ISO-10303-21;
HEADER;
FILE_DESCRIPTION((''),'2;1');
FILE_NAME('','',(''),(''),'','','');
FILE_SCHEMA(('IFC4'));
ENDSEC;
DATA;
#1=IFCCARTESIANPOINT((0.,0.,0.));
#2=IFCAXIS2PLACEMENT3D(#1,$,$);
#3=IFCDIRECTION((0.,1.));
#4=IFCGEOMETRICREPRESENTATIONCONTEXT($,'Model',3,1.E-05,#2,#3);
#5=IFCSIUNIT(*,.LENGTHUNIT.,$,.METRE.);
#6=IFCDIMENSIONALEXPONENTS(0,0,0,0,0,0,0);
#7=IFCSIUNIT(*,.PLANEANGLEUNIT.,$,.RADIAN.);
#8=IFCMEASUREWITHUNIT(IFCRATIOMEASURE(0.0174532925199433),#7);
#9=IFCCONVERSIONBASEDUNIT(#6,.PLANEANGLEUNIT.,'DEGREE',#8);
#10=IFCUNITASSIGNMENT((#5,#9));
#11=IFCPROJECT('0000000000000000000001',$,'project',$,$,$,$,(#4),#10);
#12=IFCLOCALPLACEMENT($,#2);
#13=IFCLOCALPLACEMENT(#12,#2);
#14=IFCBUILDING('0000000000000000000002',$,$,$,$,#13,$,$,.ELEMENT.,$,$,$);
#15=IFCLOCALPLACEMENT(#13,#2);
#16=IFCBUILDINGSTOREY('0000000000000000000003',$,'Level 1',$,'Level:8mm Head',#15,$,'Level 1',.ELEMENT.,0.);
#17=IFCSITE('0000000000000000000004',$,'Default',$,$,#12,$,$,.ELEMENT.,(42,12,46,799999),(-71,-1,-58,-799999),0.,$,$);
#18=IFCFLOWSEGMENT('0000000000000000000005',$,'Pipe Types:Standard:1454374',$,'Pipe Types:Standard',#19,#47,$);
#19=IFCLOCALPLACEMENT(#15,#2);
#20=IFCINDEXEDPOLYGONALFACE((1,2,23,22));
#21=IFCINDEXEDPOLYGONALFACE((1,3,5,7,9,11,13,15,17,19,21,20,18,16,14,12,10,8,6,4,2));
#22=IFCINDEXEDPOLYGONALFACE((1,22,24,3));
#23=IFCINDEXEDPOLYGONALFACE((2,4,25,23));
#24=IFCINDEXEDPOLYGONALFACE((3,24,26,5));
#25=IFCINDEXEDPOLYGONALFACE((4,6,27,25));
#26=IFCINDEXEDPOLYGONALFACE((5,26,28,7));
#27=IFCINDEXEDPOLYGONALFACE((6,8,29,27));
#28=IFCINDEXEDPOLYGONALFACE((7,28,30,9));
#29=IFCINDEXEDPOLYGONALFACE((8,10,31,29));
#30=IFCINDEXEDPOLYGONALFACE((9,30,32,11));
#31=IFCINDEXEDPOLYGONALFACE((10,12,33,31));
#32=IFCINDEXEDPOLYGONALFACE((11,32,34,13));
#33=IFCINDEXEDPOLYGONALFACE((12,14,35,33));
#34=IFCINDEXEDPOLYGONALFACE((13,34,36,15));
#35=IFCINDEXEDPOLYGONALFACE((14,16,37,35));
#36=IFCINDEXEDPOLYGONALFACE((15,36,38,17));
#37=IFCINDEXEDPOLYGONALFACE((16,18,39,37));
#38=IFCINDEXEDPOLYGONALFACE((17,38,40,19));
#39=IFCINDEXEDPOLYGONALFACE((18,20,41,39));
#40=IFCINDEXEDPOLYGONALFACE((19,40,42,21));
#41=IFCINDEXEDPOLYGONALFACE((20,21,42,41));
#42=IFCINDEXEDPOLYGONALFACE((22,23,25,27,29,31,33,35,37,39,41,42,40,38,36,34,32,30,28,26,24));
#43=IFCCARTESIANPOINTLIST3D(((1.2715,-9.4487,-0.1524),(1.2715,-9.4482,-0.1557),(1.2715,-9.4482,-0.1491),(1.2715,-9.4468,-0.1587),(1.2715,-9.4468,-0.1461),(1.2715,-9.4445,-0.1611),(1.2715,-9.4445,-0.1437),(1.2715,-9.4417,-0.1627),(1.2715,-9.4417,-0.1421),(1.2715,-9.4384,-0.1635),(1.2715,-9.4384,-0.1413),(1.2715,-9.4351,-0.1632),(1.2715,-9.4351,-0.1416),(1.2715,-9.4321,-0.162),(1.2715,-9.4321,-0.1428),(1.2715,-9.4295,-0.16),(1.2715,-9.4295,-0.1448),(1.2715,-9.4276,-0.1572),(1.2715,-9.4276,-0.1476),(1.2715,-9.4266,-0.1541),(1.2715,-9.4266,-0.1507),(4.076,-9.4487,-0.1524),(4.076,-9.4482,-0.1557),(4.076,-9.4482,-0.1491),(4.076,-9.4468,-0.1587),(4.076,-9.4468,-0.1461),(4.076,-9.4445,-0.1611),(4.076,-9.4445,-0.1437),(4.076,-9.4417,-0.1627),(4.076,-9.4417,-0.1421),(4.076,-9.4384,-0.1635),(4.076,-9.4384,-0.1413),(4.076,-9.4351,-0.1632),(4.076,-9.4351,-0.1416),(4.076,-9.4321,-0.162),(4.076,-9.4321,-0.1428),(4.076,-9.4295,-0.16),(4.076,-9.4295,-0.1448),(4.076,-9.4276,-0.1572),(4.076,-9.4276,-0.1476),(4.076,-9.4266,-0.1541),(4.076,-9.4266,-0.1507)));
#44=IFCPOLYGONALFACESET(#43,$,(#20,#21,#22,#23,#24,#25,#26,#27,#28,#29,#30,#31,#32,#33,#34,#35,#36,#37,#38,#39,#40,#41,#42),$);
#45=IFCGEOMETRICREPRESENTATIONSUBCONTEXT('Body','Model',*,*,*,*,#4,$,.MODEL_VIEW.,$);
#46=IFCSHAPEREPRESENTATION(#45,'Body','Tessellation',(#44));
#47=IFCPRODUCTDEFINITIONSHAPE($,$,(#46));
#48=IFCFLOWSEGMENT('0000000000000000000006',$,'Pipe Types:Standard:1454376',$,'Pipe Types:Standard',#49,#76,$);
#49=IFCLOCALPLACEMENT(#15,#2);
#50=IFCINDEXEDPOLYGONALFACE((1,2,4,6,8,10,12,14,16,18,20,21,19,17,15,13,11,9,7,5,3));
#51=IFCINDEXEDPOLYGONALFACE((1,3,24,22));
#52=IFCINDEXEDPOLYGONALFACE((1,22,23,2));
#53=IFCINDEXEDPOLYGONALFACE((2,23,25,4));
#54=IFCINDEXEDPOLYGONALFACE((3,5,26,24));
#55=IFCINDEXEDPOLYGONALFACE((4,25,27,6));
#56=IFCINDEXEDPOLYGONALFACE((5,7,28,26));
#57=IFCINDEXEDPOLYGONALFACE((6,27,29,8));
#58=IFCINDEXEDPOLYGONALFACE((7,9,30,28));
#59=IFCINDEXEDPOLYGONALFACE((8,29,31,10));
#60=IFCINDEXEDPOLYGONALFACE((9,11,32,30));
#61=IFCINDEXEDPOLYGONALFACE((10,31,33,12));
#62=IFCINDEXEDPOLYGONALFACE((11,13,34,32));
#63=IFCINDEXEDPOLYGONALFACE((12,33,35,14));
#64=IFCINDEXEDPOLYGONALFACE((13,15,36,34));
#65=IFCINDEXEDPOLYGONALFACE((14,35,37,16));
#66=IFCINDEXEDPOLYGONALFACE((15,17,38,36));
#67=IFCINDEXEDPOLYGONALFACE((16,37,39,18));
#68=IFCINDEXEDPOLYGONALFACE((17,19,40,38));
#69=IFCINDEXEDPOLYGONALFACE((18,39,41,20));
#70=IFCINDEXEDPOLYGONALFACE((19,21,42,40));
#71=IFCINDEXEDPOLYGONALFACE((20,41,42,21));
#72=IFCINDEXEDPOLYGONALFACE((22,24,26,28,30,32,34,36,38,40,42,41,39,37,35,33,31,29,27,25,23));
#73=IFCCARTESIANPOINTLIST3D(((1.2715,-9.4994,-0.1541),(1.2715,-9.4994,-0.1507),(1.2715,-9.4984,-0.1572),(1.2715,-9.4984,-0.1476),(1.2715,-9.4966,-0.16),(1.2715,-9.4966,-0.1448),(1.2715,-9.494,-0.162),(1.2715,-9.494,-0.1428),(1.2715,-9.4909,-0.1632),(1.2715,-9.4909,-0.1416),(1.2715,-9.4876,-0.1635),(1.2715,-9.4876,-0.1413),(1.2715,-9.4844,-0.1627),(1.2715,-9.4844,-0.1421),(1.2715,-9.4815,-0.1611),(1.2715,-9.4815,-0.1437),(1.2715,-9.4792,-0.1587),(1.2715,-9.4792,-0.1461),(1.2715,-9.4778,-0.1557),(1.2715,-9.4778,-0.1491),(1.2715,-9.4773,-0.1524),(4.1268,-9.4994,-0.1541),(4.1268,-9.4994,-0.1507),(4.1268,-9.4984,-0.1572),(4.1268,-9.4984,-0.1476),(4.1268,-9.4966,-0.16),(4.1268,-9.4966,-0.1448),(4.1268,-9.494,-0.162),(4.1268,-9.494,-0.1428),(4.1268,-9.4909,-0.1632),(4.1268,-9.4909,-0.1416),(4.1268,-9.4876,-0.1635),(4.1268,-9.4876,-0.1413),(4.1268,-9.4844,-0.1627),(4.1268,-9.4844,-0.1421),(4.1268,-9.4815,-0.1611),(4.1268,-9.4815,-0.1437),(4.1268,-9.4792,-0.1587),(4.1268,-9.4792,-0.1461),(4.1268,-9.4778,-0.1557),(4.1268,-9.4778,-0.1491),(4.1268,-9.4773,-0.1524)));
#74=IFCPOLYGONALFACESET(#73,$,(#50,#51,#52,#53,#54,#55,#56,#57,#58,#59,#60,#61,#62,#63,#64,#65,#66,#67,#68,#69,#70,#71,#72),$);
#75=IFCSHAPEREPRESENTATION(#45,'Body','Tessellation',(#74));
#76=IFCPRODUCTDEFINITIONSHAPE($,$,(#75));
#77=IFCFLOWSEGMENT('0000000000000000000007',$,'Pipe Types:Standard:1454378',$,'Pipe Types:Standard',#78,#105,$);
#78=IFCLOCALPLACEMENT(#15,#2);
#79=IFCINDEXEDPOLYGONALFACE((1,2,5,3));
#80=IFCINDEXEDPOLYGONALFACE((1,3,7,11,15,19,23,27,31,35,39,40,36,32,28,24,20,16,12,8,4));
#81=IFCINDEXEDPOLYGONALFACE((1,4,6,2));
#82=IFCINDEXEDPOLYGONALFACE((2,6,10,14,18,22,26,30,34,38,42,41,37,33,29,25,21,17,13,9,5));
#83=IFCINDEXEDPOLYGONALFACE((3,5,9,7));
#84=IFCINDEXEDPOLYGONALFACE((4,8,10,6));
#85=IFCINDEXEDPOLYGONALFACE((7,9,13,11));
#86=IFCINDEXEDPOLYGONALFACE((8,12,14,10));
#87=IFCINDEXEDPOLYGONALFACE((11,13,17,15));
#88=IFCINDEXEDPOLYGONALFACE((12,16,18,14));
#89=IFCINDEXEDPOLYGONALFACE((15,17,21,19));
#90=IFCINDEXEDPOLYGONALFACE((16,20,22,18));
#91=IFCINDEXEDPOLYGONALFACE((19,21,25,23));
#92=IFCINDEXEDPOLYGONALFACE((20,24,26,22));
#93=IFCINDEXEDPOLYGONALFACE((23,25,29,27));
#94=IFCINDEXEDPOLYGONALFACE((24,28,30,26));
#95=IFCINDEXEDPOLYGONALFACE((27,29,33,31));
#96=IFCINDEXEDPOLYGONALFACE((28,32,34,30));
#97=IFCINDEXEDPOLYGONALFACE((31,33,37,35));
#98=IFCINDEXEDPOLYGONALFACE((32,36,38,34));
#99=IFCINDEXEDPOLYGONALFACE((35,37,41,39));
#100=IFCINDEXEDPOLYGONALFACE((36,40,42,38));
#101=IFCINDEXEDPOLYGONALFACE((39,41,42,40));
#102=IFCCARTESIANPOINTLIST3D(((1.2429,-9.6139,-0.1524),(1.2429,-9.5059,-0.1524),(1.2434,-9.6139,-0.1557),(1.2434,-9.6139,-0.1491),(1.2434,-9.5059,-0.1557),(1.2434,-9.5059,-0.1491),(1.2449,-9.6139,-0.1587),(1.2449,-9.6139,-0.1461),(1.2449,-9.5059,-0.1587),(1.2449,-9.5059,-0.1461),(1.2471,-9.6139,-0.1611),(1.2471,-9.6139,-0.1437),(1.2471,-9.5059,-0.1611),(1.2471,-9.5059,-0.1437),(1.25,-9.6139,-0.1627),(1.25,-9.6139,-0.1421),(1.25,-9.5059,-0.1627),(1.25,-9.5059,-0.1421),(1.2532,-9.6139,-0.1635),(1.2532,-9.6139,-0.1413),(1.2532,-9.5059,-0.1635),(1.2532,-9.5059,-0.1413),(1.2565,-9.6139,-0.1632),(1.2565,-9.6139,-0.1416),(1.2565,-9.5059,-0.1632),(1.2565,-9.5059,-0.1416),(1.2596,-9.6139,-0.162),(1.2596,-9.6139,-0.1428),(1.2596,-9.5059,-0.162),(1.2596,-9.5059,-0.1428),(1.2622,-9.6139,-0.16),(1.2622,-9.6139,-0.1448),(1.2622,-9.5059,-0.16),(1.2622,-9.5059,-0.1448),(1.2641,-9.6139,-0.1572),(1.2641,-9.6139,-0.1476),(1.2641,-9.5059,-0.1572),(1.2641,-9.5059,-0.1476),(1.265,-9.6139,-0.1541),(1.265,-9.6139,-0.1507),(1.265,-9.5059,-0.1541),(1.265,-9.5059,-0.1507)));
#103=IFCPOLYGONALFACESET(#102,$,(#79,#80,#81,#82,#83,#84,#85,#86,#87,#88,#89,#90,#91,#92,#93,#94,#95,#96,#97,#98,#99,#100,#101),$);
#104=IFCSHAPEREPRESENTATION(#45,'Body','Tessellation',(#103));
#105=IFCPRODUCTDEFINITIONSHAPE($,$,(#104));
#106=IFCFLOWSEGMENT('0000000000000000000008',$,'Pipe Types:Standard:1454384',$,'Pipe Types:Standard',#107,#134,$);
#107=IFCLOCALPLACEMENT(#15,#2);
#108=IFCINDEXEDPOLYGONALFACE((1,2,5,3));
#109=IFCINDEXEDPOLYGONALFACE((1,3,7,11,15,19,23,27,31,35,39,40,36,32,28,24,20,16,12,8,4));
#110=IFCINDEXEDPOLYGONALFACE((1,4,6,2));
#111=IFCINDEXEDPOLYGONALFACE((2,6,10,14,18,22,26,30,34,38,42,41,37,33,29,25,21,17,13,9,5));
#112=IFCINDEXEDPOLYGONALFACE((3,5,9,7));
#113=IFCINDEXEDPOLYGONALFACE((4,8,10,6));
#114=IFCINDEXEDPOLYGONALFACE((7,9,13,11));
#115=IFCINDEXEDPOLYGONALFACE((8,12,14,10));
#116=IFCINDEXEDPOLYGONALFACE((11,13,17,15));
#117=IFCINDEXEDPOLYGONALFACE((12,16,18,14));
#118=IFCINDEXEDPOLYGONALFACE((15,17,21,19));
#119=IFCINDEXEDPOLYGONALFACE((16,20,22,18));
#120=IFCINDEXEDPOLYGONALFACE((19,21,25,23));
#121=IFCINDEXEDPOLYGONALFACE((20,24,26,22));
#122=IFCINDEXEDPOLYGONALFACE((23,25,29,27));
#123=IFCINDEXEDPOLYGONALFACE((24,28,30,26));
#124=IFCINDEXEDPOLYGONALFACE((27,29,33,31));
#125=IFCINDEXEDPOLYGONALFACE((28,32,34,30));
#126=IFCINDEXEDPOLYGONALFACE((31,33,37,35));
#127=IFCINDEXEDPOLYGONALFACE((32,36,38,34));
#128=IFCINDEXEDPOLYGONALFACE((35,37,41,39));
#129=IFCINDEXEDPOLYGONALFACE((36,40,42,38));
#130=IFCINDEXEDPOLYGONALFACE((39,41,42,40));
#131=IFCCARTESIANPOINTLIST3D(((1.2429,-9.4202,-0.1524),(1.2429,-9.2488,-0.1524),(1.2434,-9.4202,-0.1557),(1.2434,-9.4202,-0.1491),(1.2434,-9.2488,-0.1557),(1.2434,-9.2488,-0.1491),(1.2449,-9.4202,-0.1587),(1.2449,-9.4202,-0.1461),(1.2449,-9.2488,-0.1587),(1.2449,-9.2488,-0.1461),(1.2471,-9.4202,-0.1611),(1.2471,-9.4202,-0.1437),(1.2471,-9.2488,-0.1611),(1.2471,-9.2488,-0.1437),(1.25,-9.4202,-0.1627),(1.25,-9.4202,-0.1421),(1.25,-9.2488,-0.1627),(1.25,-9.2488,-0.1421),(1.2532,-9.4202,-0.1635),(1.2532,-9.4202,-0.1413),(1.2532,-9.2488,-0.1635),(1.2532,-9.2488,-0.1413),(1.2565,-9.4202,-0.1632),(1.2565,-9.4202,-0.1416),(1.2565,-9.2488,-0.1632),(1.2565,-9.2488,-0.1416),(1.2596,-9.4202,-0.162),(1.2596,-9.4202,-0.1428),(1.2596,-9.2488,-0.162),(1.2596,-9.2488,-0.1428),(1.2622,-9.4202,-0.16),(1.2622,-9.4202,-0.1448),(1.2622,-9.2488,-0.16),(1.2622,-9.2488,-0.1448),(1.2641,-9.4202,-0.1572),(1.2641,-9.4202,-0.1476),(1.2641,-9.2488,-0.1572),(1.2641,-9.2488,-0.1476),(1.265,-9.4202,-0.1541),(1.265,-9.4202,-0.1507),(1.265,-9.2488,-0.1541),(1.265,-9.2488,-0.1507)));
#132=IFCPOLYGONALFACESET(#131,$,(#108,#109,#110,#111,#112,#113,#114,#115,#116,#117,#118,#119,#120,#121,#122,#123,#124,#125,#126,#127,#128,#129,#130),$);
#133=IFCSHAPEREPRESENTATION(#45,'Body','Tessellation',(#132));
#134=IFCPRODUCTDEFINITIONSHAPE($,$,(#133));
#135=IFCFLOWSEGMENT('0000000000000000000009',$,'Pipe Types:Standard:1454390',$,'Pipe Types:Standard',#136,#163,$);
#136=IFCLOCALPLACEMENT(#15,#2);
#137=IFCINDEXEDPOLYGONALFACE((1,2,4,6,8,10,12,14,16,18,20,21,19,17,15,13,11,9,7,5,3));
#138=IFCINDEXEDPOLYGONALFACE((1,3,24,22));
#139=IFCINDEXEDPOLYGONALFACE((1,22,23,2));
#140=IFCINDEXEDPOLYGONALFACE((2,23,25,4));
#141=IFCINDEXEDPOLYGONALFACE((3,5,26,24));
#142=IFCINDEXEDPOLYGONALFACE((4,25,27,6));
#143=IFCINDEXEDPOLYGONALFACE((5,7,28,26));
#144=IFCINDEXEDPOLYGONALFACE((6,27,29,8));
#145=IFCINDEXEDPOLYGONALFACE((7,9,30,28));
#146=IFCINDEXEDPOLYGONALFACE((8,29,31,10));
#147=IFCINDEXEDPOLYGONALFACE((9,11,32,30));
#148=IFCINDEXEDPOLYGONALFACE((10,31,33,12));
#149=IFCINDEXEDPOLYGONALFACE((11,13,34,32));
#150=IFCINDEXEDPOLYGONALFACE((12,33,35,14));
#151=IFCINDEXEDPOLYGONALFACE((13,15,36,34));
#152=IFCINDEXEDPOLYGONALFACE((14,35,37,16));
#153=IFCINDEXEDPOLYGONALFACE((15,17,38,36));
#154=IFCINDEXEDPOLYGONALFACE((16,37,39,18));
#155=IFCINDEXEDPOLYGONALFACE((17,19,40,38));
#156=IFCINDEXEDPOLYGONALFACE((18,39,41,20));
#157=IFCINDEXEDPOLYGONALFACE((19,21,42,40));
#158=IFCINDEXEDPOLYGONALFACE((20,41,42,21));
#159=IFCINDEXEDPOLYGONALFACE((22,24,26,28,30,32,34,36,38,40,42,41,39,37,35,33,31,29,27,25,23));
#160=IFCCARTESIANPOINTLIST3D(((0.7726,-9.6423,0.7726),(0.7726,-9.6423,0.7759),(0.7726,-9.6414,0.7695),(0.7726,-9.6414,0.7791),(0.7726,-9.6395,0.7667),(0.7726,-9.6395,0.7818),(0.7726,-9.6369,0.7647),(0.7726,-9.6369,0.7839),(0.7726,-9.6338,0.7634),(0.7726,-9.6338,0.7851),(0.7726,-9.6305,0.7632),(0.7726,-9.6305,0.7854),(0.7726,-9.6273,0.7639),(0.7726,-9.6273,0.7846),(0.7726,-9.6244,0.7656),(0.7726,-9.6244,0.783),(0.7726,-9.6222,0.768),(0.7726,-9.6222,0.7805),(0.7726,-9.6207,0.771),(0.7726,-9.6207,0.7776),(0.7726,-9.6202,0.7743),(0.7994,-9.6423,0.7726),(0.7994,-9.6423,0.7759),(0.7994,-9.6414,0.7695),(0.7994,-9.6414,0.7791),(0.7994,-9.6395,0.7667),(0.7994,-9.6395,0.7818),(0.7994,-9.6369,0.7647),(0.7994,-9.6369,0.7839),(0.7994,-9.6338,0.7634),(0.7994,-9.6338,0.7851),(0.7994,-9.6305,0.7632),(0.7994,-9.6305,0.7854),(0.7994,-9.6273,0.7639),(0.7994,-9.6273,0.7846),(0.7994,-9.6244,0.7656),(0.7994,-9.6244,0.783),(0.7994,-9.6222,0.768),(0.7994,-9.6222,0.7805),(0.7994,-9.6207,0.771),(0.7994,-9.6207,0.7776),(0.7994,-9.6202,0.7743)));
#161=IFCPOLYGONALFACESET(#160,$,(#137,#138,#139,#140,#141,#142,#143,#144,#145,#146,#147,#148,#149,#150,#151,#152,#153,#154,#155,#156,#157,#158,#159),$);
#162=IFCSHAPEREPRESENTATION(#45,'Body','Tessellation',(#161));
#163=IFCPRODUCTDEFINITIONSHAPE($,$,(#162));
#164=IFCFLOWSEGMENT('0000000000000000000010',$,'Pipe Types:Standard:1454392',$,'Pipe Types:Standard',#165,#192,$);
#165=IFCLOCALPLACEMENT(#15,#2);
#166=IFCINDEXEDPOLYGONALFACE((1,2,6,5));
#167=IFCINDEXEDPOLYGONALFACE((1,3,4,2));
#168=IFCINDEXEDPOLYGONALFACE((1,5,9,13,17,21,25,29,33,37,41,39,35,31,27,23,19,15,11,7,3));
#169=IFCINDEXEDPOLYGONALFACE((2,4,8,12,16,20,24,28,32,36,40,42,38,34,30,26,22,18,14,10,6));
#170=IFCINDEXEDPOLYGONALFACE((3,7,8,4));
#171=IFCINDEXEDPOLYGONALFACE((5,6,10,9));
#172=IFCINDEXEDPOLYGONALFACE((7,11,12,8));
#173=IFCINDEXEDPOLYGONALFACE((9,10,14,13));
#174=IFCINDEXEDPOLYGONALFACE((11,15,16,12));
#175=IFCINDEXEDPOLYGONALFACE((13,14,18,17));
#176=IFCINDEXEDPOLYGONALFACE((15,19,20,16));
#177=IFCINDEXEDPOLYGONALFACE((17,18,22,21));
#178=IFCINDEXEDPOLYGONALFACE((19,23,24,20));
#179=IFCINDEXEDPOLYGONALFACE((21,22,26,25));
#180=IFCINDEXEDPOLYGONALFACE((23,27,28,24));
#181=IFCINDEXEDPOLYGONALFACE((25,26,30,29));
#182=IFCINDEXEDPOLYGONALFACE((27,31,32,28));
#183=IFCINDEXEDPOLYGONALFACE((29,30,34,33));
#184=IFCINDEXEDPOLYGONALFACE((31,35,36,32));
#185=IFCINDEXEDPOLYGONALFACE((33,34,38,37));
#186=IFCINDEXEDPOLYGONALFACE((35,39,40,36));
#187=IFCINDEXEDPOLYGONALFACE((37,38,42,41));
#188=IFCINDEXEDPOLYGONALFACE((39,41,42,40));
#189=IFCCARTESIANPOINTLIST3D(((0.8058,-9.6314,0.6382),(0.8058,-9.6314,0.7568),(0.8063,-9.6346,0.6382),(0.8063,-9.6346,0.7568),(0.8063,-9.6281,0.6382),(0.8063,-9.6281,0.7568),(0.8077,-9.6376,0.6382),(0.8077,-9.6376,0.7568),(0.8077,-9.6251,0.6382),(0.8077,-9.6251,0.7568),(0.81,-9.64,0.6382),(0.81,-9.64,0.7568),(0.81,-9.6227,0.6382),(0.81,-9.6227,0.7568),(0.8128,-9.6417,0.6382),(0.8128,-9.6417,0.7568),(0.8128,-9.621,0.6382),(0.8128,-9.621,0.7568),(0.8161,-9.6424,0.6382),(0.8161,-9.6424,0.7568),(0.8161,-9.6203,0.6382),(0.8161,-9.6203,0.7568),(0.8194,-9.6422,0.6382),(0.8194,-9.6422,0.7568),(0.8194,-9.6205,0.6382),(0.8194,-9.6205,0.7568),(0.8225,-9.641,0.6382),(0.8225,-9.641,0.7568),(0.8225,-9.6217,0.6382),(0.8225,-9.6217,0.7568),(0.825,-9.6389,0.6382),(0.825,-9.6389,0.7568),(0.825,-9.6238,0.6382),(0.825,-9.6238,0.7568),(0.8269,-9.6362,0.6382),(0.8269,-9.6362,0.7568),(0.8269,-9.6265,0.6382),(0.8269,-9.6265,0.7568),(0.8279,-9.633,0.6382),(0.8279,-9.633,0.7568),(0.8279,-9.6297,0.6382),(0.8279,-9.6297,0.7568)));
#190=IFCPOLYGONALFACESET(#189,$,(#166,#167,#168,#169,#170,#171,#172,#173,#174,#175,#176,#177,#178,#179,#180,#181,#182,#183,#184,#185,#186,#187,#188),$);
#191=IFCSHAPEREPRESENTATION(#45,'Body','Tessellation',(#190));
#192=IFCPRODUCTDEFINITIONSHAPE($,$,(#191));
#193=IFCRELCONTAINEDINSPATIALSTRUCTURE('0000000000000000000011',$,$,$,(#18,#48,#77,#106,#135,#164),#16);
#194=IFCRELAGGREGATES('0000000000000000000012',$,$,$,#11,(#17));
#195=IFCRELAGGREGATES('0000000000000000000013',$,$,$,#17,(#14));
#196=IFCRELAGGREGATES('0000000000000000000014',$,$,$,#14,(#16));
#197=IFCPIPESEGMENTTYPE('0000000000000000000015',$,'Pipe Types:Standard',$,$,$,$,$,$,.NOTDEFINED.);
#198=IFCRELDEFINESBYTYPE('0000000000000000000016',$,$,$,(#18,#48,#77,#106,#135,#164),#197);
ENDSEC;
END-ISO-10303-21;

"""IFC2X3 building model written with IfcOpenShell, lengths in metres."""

from ifc_helpers import new_model, entity, si_unit, converted_unit, direction, frame, frame_2d, origin, origin_2d_with_axis, place, context, subcontext, project, spatial, circle, extrude, type_object, element, save


model = new_model("IFC2X3")

# Units and contexts
model_context = context("Model", 3, precision=1e-05, world=origin(), true_north=direction((0.0, 1.0)))
body_context = subcontext(model_context, "Body", "Model", "MODEL_VIEW")
ifc_project = project(units=[si_unit("LENGTHUNIT", "METRE"), converted_unit("PLANEANGLEUNIT", "DEGREE", entity("IfcRatioMeasure", 0.0174532925199433), si_unit("PLANEANGLEUNIT", "RADIAN"), dimensions=[0, 0, 0, 0, 0, 0, 0])], contexts=[model_context])

# Site, building, storey
site_placement = place(None, origin())
site = spatial("IfcSite", under=ifc_project, at=site_placement, Name="Default", CompositionType="ELEMENT", RefLatitude=(42, 12, 46, 799999), RefLongitude=(-71, -1, -58, -799999), RefElevation=0.0)
building_placement = place(site_placement, origin())
building = spatial("IfcBuilding", under=site, at=building_placement, CompositionType="ELEMENT")
storey_placement = place(building_placement, origin())
storey = spatial("IfcBuildingStorey", under=building, at=storey_placement, Name="Level 1", ObjectType="Level:8mm Head", LongName="Level 1", CompositionType="ELEMENT", Elevation=0.0)

# Flow segments
pipe_segment_type = type_object("IfcPipeSegmentType", Name="Pipe Types:Standard", PredefinedType="NOTDEFINED")
flow_segment_1_placement = place(storey_placement, origin())
element("IfcFlowSegment", 1, at=flow_segment_1_placement, inside=storey, type_object=pipe_segment_type, Name="Pipe Types:Standard:1454374", ObjectType="Pipe Types:Standard", context=body_context, shape_type="SweptSolid", body=[
    extrude(circle(Radius=0.0111, at=origin_2d_with_axis()), frame((1.2715, -9.4376, -0.1524), z_axis=(1.0, 0.0, 0.0), x_axis=(0.0, -1.0, 0.0)), (0.0, 0.0, 1.0), 2.8045),
])
flow_segment_2_placement = place(storey_placement, origin())
element("IfcFlowSegment", 2, at=flow_segment_2_placement, inside=storey, type_object=pipe_segment_type, Name="Pipe Types:Standard:1454376", ObjectType="Pipe Types:Standard", context=body_context, shape_type="SweptSolid", body=[
    extrude(circle(Radius=0.0111, at=frame_2d((0.0, 0.0), x_axis=(1.0, 0.0))), frame((1.2715, -9.4884, -0.1524), z_axis=(1.0, 0.0, 0.0), x_axis=(0.0, 1.0, 0.0)), (0.0, 0.0, 1.0), 2.8553),
])
flow_segment_3_placement = place(storey_placement, origin())
element("IfcFlowSegment", 3, at=flow_segment_3_placement, inside=storey, type_object=pipe_segment_type, Name="Pipe Types:Standard:1454378", ObjectType="Pipe Types:Standard", context=body_context, shape_type="SweptSolid", body=[
    extrude(circle(Radius=0.0111, at=frame_2d((0.0, 0.0), x_axis=(1.0, 0.0))), frame((1.254, -9.6139, -0.1524), z_axis=(0.0, 1.0, 0.0), x_axis=(-1.0, 0.0, 0.0)), (0.0, 0.0, 1.0), 0.108),
])
flow_segment_4_placement = place(storey_placement, origin())
element("IfcFlowSegment", 4, at=flow_segment_4_placement, inside=storey, type_object=pipe_segment_type, Name="Pipe Types:Standard:1454384", ObjectType="Pipe Types:Standard", context=body_context, shape_type="SweptSolid", body=[
    extrude(circle(Radius=0.0111, at=frame_2d((0.0, 0.0), x_axis=(1.0, 0.0))), frame((1.254, -9.4202, -0.1524), z_axis=(0.0, 1.0, 0.0), x_axis=(-1.0, 0.0, 0.0)), (0.0, 0.0, 1.0), 0.1713),
])
flow_segment_5_placement = place(storey_placement, origin())
element("IfcFlowSegment", 5, at=flow_segment_5_placement, inside=storey, type_object=pipe_segment_type, Name="Pipe Types:Standard:1454390", ObjectType="Pipe Types:Standard", context=body_context, shape_type="SweptSolid", body=[
    extrude(circle(Radius=0.0111, at=frame_2d((0.0, 0.0), x_axis=(1.0, 0.0))), frame((0.7726, -9.6314, 0.7743), z_axis=(1.0, 0.0, 0.0), x_axis=(0.0, 1.0, 0.0)), (0.0, 0.0, 1.0), 0.0269),
])
flow_segment_6_placement = place(storey_placement, origin())
element("IfcFlowSegment", 6, at=flow_segment_6_placement, inside=storey, type_object=pipe_segment_type, Name="Pipe Types:Standard:1454392", ObjectType="Pipe Types:Standard", context=body_context, shape_type="SweptSolid", body=[
    extrude(circle(Radius=0.0111, at=frame_2d((0.0, 0.0), x_axis=(1.0, 0.0))), frame((0.8169, -9.6314, 0.6382), z_axis=(0.0, 0.0, 1.0), x_axis=(-1.0, 0.0, 0.0)), (0.0, 0.0, 1.0), 0.1186),
])

save(model, "model.ifc")
